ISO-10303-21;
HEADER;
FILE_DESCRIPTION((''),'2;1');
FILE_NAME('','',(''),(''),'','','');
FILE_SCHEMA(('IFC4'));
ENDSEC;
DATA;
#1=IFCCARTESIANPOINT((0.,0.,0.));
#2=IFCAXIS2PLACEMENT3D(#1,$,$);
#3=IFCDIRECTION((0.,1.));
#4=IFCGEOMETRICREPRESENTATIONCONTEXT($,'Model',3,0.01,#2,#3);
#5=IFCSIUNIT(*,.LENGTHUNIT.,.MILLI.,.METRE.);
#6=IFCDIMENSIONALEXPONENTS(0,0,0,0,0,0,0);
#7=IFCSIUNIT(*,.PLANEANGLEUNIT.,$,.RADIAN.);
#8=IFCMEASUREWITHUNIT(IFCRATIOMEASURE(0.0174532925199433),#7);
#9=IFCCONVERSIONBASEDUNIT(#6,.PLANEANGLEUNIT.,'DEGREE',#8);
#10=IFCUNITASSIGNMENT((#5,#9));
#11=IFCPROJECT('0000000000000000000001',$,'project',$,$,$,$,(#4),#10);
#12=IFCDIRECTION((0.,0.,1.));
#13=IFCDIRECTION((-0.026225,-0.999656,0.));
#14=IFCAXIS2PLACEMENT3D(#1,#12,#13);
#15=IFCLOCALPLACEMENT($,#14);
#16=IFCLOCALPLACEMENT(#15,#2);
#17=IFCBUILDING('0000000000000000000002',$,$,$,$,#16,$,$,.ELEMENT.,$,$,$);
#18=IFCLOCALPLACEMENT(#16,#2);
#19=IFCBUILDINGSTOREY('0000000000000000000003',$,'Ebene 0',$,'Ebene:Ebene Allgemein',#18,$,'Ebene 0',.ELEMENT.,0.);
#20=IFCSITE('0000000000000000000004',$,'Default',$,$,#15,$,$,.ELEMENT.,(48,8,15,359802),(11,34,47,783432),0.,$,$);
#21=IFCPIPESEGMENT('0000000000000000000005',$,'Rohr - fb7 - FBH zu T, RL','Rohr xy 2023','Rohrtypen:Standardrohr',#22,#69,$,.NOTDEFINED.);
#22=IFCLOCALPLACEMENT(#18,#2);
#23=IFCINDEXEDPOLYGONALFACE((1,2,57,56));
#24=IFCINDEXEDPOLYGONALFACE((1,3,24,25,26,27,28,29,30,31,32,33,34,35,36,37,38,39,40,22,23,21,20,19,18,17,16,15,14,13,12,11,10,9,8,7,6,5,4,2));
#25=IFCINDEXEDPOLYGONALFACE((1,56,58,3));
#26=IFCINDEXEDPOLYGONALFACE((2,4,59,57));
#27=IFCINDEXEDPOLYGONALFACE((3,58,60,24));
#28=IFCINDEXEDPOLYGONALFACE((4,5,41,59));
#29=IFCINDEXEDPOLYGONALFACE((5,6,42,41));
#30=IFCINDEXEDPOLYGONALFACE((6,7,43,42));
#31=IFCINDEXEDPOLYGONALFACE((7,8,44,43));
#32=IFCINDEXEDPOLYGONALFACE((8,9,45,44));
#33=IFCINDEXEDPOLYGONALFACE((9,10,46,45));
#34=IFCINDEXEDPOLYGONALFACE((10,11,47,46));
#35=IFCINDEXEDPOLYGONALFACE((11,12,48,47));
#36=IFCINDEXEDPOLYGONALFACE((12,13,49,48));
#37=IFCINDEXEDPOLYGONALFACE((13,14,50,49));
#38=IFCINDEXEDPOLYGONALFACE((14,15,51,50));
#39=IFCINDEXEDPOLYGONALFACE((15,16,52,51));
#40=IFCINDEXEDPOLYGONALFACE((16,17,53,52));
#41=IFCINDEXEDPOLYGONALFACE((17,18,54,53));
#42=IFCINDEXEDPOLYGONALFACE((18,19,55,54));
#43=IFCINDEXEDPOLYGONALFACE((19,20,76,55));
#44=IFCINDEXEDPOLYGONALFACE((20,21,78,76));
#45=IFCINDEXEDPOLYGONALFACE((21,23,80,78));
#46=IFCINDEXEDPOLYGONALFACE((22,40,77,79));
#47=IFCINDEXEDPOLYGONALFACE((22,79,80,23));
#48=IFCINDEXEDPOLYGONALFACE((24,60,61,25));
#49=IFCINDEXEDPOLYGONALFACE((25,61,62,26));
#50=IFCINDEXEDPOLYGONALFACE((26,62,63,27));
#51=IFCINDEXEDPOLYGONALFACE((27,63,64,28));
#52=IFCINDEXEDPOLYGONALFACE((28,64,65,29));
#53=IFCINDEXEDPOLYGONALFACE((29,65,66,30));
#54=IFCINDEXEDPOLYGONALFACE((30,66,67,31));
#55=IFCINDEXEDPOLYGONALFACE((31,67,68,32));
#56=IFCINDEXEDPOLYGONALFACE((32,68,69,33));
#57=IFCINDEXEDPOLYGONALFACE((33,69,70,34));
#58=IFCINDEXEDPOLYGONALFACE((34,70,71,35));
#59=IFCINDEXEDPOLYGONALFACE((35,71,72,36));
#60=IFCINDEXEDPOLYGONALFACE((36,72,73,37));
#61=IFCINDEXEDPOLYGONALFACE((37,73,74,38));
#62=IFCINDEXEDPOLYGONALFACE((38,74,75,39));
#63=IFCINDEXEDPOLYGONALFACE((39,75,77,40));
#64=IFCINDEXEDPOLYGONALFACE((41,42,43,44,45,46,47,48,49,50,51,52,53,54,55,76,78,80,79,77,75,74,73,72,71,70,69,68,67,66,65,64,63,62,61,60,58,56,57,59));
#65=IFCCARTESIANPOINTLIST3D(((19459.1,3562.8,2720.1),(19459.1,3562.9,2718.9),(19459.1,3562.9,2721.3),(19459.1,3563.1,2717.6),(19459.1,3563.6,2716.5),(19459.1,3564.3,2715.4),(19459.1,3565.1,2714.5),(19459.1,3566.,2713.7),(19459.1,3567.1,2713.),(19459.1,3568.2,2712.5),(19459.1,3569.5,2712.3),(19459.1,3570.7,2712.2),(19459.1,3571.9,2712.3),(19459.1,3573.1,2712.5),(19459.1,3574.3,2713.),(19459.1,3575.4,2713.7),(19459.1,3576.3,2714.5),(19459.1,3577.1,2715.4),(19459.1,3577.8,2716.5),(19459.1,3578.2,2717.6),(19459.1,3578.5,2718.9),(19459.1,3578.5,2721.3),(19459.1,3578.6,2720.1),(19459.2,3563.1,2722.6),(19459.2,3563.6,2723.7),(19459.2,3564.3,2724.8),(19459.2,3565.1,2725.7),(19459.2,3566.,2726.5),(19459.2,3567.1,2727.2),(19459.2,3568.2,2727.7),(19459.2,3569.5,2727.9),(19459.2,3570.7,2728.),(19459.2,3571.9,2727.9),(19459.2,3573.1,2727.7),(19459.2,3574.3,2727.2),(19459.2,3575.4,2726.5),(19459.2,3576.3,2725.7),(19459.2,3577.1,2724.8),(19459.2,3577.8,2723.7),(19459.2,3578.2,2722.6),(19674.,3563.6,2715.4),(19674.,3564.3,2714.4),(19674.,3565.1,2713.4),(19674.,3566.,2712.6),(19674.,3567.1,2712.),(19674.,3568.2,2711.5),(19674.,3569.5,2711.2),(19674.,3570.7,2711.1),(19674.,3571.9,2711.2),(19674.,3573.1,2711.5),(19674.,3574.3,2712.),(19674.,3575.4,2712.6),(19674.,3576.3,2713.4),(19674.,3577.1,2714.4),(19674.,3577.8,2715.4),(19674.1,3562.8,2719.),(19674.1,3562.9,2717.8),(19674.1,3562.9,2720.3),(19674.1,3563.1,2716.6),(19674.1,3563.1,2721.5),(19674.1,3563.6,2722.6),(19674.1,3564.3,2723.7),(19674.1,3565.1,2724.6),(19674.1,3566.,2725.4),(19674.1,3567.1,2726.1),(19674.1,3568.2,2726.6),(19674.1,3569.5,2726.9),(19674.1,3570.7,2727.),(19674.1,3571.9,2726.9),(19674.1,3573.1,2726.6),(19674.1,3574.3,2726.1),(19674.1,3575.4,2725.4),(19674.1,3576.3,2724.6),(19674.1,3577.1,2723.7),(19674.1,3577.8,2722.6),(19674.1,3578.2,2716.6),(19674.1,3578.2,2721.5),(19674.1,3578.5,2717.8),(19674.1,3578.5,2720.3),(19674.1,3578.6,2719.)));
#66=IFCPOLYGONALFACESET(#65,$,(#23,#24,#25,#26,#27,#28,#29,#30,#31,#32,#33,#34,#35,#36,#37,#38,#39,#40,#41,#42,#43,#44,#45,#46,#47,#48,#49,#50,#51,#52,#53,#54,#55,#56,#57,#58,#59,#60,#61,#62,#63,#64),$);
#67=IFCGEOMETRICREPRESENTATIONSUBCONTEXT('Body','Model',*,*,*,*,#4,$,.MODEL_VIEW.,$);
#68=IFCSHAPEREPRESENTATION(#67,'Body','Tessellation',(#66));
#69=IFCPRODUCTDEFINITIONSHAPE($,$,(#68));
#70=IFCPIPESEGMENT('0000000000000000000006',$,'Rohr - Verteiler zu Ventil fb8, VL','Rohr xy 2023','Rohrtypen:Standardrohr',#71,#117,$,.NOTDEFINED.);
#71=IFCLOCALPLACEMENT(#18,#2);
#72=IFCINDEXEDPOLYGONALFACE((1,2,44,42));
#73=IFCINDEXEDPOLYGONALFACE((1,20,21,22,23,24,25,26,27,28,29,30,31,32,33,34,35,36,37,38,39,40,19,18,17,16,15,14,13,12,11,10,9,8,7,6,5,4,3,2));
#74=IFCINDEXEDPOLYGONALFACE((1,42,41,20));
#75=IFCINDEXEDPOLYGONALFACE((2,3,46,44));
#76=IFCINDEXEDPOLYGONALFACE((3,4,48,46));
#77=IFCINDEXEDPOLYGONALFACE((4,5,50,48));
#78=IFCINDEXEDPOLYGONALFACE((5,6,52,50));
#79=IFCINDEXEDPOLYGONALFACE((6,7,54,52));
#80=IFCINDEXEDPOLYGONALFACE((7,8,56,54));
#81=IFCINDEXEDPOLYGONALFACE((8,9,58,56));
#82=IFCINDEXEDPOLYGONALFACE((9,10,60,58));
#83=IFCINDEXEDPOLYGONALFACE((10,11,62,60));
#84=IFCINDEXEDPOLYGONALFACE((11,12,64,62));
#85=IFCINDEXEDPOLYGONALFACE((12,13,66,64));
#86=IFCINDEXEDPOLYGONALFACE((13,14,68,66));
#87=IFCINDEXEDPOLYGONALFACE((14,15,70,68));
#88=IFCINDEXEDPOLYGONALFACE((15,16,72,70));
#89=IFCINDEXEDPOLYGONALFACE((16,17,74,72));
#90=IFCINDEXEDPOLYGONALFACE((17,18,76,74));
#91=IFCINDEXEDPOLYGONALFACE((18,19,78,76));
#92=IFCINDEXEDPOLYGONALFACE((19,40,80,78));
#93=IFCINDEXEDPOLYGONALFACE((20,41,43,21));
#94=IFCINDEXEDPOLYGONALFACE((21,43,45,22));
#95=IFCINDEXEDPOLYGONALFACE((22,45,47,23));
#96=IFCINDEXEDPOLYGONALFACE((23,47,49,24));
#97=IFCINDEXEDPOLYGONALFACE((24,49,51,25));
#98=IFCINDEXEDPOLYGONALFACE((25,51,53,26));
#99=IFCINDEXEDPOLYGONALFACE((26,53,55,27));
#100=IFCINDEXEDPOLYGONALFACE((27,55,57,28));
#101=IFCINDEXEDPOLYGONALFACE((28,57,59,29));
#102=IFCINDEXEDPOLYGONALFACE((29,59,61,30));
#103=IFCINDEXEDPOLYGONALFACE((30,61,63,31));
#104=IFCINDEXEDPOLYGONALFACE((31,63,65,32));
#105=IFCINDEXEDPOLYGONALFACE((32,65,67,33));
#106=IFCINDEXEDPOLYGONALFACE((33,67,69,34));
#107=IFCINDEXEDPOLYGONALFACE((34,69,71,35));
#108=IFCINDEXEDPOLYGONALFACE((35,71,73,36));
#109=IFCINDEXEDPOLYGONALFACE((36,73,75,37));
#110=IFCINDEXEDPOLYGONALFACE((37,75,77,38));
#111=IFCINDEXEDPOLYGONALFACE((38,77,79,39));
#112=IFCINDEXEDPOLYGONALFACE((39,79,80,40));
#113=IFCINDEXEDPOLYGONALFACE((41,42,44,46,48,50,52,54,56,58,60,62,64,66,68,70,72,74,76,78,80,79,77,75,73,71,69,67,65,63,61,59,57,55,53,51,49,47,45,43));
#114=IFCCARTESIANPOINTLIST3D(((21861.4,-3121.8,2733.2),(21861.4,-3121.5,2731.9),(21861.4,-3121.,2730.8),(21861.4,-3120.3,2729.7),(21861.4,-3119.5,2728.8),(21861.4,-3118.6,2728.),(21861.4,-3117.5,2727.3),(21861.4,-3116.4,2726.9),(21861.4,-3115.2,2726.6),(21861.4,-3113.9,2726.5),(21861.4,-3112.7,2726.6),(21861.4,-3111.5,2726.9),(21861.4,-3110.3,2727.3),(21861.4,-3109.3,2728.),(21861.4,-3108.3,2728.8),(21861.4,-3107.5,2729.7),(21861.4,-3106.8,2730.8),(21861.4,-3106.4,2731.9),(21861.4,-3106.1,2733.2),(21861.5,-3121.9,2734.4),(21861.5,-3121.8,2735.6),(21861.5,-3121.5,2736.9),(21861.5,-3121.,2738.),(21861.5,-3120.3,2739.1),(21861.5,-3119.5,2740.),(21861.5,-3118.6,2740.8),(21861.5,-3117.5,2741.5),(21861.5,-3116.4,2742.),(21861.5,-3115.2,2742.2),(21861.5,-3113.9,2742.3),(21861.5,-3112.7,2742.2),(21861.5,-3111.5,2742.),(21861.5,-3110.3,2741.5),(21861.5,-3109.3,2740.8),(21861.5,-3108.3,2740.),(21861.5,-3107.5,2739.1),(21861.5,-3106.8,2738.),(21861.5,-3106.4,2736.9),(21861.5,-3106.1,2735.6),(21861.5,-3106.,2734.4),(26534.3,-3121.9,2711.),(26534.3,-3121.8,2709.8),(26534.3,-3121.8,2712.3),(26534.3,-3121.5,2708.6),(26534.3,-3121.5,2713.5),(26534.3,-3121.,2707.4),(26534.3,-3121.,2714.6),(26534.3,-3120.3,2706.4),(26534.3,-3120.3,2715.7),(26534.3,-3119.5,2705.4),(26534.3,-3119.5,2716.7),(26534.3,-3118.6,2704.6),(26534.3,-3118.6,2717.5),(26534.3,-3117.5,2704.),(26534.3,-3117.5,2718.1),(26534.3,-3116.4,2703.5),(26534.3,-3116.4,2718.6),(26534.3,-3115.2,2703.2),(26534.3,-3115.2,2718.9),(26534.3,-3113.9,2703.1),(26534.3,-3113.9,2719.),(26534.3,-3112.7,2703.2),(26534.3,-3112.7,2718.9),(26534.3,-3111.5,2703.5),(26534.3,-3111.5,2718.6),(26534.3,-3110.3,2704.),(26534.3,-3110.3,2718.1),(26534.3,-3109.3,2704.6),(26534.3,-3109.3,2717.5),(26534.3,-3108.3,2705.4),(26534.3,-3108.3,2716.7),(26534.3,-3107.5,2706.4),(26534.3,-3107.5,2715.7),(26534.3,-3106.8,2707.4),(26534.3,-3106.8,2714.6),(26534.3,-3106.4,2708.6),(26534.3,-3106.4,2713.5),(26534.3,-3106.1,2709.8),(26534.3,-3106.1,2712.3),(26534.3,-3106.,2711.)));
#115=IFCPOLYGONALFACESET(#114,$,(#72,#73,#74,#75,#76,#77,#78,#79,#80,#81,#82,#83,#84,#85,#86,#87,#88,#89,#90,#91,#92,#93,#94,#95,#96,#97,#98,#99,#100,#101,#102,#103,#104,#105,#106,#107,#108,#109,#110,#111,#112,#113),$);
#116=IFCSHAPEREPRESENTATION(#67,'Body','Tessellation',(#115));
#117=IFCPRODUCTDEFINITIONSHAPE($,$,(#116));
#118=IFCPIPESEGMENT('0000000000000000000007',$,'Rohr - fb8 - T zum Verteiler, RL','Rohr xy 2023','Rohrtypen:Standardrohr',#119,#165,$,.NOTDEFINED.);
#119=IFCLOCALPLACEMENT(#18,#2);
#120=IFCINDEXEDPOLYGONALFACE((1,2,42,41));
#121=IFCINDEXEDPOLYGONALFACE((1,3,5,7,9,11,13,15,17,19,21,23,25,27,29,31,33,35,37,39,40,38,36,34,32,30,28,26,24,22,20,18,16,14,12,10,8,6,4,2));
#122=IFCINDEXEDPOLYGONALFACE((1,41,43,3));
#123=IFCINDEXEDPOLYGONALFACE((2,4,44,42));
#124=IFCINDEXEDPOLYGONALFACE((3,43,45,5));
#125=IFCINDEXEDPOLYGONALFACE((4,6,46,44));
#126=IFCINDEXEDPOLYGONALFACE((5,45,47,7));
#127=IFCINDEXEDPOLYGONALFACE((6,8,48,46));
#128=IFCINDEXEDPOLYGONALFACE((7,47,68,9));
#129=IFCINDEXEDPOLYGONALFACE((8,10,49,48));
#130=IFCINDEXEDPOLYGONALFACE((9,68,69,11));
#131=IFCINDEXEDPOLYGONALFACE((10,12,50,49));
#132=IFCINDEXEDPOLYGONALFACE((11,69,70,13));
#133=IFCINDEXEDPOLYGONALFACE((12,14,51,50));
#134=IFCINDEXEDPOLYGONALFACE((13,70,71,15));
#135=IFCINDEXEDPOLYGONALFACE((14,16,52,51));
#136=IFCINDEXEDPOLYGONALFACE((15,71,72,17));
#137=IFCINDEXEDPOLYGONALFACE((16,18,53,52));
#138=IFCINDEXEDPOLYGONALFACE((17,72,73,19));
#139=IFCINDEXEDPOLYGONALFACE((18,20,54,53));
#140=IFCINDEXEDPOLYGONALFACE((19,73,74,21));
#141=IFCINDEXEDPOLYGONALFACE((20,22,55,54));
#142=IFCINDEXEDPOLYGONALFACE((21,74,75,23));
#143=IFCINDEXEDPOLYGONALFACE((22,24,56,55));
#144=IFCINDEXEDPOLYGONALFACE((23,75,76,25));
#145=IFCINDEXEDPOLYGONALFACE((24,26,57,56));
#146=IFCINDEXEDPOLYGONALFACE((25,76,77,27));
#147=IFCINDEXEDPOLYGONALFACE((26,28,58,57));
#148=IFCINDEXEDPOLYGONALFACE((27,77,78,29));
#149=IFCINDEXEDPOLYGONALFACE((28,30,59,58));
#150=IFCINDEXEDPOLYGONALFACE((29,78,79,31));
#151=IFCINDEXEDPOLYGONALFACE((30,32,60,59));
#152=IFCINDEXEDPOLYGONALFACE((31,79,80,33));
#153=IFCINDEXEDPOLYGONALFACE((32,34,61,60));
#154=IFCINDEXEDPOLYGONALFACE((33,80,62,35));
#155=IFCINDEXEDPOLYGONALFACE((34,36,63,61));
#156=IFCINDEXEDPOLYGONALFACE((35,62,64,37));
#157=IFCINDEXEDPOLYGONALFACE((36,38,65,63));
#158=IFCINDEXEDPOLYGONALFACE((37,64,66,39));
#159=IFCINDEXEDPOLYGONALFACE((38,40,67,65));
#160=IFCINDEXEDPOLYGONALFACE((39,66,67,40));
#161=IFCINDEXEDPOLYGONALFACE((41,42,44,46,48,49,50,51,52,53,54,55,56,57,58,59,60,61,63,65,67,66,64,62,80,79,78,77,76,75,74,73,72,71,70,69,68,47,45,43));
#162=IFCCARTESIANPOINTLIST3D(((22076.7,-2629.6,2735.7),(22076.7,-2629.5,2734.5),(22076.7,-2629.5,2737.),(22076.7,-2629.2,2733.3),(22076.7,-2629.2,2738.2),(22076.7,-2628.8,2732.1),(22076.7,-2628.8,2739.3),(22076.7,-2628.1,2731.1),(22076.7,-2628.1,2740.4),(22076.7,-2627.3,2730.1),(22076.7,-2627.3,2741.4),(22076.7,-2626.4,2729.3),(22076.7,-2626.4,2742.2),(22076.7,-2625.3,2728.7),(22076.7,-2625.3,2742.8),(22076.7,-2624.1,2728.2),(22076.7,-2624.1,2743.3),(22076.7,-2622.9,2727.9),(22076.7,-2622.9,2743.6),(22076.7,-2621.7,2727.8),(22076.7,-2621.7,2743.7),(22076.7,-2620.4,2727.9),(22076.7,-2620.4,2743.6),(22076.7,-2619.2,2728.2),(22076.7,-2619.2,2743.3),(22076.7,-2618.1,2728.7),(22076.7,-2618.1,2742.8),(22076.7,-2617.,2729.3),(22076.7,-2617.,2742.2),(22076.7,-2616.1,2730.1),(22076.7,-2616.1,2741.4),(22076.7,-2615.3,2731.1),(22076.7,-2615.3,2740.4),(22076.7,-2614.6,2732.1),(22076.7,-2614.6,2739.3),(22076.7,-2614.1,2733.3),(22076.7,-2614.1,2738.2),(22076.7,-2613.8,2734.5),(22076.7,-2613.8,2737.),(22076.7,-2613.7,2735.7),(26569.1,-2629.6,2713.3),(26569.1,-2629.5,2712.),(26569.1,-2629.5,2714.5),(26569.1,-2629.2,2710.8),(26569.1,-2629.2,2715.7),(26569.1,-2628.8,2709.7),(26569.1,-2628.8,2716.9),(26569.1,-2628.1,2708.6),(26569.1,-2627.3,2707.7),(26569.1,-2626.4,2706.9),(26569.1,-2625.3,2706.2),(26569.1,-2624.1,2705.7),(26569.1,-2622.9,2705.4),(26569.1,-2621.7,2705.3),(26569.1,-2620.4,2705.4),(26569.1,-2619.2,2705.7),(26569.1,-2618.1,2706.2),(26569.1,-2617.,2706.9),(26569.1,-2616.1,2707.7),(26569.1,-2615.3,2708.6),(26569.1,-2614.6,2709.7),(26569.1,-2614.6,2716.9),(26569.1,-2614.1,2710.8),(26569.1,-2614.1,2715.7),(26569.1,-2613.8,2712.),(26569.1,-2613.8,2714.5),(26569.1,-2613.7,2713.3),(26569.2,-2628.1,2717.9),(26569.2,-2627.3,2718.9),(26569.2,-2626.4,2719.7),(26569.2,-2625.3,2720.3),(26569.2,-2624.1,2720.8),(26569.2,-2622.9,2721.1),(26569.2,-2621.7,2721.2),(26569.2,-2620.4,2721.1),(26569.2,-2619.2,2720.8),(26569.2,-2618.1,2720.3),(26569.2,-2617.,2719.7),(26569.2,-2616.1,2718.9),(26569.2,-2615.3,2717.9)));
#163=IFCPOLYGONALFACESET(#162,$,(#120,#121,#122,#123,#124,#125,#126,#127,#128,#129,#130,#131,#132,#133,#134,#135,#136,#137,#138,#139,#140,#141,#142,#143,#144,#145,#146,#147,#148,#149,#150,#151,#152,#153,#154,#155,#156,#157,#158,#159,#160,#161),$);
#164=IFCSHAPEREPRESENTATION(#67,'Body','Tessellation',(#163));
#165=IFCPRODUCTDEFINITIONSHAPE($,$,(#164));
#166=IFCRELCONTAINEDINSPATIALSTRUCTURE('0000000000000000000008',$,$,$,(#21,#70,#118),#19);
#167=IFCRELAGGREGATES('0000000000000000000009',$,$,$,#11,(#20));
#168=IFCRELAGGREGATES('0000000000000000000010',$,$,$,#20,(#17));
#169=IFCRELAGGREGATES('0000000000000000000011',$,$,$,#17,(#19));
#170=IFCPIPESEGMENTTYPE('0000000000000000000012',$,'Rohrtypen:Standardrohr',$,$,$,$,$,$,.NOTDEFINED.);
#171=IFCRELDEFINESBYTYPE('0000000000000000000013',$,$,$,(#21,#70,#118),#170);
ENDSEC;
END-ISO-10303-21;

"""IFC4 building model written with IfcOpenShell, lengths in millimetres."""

from ifc_helpers import new_model, entity, si_unit, converted_unit, direction, frame, origin, place, context, subcontext, project, spatial, indexed_curve, outline, extrude, type_object, element, save


model = new_model("IFC4")

# Units and contexts
model_context = context("Model", 3, precision=0.01, world=origin(), true_north=direction((0.0, 1.0)))
body_context = subcontext(model_context, "Body", "Model", "MODEL_VIEW")
ifc_project = project(units=[si_unit("LENGTHUNIT", "METRE", prefix="MILLI"), converted_unit("PLANEANGLEUNIT", "DEGREE", entity("IfcRatioMeasure", 0.0174532925199433), si_unit("PLANEANGLEUNIT", "RADIAN"), dimensions=[0, 0, 0, 0, 0, 0, 0])], contexts=[model_context])

# Site, building, storey
site_placement = place(None, frame((0.0, 0.0, 0.0), z_axis=(0.0, 0.0, 1.0), x_axis=(-0.026225, -0.999656, 0.0)))
site = spatial("IfcSite", under=ifc_project, at=site_placement, Name="Default", CompositionType="ELEMENT", RefLatitude=(48, 8, 15, 359802), RefLongitude=(11, 34, 47, 783432), RefElevation=0.0)
building_placement = place(site_placement, origin())
building = spatial("IfcBuilding", under=site, at=building_placement, CompositionType="ELEMENT")
storey_placement = place(building_placement, origin())
storey = spatial("IfcBuildingStorey", under=building, at=storey_placement, Name="Ebene 0", ObjectType="Ebene:Ebene Allgemein", LongName="Ebene 0", CompositionType="ELEMENT", Elevation=0.0)

# Pipe segments
pipe_segment_type = type_object("IfcPipeSegmentType", Name="Rohrtypen:Standardrohr", PredefinedType="NOTDEFINED")
pipe_segment_1_placement = place(storey_placement, origin())
element("IfcPipeSegment", 1, at=pipe_segment_1_placement, inside=storey, type_object=pipe_segment_type, Name="Rohr - fb7 - FBH zu T, RL", Description="Rohr xy 2023", ObjectType="Rohrtypen:Standardrohr", PredefinedType="NOTDEFINED", context=body_context, shape_type="SweptSolid", body=[
    extrude(outline(indexed_curve([(7.9, 0.0), (7.8, 1.2), (7.6, 2.5), (7.1, 3.6), (6.4, 4.7), (5.6, 5.6), (4.7, 6.4), (3.6, 7.1), (2.5, 7.6), (1.2, 7.8), (0.0, 7.9), (-1.2, 7.8), (-2.5, 7.6), (-3.6, 7.1), (-4.7, 6.4), (-5.6, 5.6), (-6.4, 4.7), (-7.1, 3.6), (-7.6, 2.5), (-7.8, 1.2), (-7.9, 0.0), (-7.8, -1.2), (-7.6, -2.5), (-7.1, -3.6), (-6.4, -4.7), (-5.6, -5.6), (-4.7, -6.4), (-3.6, -7.1), (-2.5, -7.6), (-1.2, -7.8), (0.0, -7.9), (1.2, -7.8), (2.5, -7.6), (3.6, -7.1), (4.7, -6.4), (5.6, -5.6), (6.4, -4.7), (7.1, -3.6), (7.6, -2.5), (7.8, -1.2), (7.9, 0.0)], self_intersect=False)), frame((19674.1, 3570.7, 2719.0), z_axis=(-0.999988, 0.0, 0.005), x_axis=(0.0, 1.0, 0.0)), (0.0, 0.0, 1.0), 214.9),
])
pipe_segment_2_placement = place(storey_placement, origin())
element("IfcPipeSegment", 2, at=pipe_segment_2_placement, inside=storey, type_object=pipe_segment_type, Name="Rohr - Verteiler zu Ventil fb8, VL", Description="Rohr xy 2023", ObjectType="Rohrtypen:Standardrohr", PredefinedType="NOTDEFINED", context=body_context, shape_type="SweptSolid", body=[
    extrude(outline(indexed_curve([(7.9, 0.0), (7.8, 1.2), (7.6, 2.5), (7.1, 3.6), (6.4, 4.7), (5.6, 5.6), (4.7, 6.4), (3.6, 7.1), (2.5, 7.6), (1.2, 7.8), (0.0, 7.9), (-1.2, 7.8), (-2.5, 7.6), (-3.6, 7.1), (-4.7, 6.4), (-5.6, 5.6), (-6.4, 4.7), (-7.1, 3.6), (-7.6, 2.5), (-7.8, 1.2), (-7.9, 0.0), (-7.8, -1.2), (-7.6, -2.5), (-7.1, -3.6), (-6.4, -4.7), (-5.6, -5.6), (-4.7, -6.4), (-3.6, -7.1), (-2.5, -7.6), (-1.2, -7.8), (0.0, -7.9), (1.2, -7.8), (2.5, -7.6), (3.6, -7.1), (4.7, -6.4), (5.6, -5.6), (6.4, -4.7), (7.1, -3.6), (7.6, -2.5), (7.8, -1.2), (7.9, 0.0)], self_intersect=False)), frame((26534.3, -3113.9, 2711.0), z_axis=(-0.999988, 0.0, 0.005), x_axis=(0.0, 1.0, 0.0)), (0.0, 0.0, 1.0), 4672.9),
])
pipe_segment_3_placement = place(storey_placement, origin())
element("IfcPipeSegment", 3, at=pipe_segment_3_placement, inside=storey, type_object=pipe_segment_type, Name="Rohr - fb8 - T zum Verteiler, RL", Description="Rohr xy 2023", ObjectType="Rohrtypen:Standardrohr", PredefinedType="NOTDEFINED", context=body_context, shape_type="SweptSolid", body=[
    extrude(outline(indexed_curve([(7.9, 0.0), (7.8, 1.2), (7.6, 2.5), (7.1, 3.6), (6.4, 4.7), (5.6, 5.6), (4.7, 6.4), (3.6, 7.1), (2.5, 7.6), (1.2, 7.8), (0.0, 7.9), (-1.2, 7.8), (-2.5, 7.6), (-3.6, 7.1), (-4.7, 6.4), (-5.6, 5.6), (-6.4, 4.7), (-7.1, 3.6), (-7.6, 2.5), (-7.8, 1.2), (-7.9, 0.0), (-7.8, -1.2), (-7.6, -2.5), (-7.1, -3.6), (-6.4, -4.7), (-5.6, -5.6), (-4.7, -6.4), (-3.6, -7.1), (-2.5, -7.6), (-1.2, -7.8), (0.0, -7.9), (1.2, -7.8), (2.5, -7.6), (3.6, -7.1), (4.7, -6.4), (5.6, -5.6), (6.4, -4.7), (7.1, -3.6), (7.6, -2.5), (7.8, -1.2), (7.9, 0.0)], self_intersect=False)), frame((26569.1, -2621.7, 2713.3), z_axis=(-0.999988, 0.0, 0.005), x_axis=(0.0, 1.0, 0.0)), (0.0, 0.0, 1.0), 4492.5),
])

save(model, "model.ifc")
